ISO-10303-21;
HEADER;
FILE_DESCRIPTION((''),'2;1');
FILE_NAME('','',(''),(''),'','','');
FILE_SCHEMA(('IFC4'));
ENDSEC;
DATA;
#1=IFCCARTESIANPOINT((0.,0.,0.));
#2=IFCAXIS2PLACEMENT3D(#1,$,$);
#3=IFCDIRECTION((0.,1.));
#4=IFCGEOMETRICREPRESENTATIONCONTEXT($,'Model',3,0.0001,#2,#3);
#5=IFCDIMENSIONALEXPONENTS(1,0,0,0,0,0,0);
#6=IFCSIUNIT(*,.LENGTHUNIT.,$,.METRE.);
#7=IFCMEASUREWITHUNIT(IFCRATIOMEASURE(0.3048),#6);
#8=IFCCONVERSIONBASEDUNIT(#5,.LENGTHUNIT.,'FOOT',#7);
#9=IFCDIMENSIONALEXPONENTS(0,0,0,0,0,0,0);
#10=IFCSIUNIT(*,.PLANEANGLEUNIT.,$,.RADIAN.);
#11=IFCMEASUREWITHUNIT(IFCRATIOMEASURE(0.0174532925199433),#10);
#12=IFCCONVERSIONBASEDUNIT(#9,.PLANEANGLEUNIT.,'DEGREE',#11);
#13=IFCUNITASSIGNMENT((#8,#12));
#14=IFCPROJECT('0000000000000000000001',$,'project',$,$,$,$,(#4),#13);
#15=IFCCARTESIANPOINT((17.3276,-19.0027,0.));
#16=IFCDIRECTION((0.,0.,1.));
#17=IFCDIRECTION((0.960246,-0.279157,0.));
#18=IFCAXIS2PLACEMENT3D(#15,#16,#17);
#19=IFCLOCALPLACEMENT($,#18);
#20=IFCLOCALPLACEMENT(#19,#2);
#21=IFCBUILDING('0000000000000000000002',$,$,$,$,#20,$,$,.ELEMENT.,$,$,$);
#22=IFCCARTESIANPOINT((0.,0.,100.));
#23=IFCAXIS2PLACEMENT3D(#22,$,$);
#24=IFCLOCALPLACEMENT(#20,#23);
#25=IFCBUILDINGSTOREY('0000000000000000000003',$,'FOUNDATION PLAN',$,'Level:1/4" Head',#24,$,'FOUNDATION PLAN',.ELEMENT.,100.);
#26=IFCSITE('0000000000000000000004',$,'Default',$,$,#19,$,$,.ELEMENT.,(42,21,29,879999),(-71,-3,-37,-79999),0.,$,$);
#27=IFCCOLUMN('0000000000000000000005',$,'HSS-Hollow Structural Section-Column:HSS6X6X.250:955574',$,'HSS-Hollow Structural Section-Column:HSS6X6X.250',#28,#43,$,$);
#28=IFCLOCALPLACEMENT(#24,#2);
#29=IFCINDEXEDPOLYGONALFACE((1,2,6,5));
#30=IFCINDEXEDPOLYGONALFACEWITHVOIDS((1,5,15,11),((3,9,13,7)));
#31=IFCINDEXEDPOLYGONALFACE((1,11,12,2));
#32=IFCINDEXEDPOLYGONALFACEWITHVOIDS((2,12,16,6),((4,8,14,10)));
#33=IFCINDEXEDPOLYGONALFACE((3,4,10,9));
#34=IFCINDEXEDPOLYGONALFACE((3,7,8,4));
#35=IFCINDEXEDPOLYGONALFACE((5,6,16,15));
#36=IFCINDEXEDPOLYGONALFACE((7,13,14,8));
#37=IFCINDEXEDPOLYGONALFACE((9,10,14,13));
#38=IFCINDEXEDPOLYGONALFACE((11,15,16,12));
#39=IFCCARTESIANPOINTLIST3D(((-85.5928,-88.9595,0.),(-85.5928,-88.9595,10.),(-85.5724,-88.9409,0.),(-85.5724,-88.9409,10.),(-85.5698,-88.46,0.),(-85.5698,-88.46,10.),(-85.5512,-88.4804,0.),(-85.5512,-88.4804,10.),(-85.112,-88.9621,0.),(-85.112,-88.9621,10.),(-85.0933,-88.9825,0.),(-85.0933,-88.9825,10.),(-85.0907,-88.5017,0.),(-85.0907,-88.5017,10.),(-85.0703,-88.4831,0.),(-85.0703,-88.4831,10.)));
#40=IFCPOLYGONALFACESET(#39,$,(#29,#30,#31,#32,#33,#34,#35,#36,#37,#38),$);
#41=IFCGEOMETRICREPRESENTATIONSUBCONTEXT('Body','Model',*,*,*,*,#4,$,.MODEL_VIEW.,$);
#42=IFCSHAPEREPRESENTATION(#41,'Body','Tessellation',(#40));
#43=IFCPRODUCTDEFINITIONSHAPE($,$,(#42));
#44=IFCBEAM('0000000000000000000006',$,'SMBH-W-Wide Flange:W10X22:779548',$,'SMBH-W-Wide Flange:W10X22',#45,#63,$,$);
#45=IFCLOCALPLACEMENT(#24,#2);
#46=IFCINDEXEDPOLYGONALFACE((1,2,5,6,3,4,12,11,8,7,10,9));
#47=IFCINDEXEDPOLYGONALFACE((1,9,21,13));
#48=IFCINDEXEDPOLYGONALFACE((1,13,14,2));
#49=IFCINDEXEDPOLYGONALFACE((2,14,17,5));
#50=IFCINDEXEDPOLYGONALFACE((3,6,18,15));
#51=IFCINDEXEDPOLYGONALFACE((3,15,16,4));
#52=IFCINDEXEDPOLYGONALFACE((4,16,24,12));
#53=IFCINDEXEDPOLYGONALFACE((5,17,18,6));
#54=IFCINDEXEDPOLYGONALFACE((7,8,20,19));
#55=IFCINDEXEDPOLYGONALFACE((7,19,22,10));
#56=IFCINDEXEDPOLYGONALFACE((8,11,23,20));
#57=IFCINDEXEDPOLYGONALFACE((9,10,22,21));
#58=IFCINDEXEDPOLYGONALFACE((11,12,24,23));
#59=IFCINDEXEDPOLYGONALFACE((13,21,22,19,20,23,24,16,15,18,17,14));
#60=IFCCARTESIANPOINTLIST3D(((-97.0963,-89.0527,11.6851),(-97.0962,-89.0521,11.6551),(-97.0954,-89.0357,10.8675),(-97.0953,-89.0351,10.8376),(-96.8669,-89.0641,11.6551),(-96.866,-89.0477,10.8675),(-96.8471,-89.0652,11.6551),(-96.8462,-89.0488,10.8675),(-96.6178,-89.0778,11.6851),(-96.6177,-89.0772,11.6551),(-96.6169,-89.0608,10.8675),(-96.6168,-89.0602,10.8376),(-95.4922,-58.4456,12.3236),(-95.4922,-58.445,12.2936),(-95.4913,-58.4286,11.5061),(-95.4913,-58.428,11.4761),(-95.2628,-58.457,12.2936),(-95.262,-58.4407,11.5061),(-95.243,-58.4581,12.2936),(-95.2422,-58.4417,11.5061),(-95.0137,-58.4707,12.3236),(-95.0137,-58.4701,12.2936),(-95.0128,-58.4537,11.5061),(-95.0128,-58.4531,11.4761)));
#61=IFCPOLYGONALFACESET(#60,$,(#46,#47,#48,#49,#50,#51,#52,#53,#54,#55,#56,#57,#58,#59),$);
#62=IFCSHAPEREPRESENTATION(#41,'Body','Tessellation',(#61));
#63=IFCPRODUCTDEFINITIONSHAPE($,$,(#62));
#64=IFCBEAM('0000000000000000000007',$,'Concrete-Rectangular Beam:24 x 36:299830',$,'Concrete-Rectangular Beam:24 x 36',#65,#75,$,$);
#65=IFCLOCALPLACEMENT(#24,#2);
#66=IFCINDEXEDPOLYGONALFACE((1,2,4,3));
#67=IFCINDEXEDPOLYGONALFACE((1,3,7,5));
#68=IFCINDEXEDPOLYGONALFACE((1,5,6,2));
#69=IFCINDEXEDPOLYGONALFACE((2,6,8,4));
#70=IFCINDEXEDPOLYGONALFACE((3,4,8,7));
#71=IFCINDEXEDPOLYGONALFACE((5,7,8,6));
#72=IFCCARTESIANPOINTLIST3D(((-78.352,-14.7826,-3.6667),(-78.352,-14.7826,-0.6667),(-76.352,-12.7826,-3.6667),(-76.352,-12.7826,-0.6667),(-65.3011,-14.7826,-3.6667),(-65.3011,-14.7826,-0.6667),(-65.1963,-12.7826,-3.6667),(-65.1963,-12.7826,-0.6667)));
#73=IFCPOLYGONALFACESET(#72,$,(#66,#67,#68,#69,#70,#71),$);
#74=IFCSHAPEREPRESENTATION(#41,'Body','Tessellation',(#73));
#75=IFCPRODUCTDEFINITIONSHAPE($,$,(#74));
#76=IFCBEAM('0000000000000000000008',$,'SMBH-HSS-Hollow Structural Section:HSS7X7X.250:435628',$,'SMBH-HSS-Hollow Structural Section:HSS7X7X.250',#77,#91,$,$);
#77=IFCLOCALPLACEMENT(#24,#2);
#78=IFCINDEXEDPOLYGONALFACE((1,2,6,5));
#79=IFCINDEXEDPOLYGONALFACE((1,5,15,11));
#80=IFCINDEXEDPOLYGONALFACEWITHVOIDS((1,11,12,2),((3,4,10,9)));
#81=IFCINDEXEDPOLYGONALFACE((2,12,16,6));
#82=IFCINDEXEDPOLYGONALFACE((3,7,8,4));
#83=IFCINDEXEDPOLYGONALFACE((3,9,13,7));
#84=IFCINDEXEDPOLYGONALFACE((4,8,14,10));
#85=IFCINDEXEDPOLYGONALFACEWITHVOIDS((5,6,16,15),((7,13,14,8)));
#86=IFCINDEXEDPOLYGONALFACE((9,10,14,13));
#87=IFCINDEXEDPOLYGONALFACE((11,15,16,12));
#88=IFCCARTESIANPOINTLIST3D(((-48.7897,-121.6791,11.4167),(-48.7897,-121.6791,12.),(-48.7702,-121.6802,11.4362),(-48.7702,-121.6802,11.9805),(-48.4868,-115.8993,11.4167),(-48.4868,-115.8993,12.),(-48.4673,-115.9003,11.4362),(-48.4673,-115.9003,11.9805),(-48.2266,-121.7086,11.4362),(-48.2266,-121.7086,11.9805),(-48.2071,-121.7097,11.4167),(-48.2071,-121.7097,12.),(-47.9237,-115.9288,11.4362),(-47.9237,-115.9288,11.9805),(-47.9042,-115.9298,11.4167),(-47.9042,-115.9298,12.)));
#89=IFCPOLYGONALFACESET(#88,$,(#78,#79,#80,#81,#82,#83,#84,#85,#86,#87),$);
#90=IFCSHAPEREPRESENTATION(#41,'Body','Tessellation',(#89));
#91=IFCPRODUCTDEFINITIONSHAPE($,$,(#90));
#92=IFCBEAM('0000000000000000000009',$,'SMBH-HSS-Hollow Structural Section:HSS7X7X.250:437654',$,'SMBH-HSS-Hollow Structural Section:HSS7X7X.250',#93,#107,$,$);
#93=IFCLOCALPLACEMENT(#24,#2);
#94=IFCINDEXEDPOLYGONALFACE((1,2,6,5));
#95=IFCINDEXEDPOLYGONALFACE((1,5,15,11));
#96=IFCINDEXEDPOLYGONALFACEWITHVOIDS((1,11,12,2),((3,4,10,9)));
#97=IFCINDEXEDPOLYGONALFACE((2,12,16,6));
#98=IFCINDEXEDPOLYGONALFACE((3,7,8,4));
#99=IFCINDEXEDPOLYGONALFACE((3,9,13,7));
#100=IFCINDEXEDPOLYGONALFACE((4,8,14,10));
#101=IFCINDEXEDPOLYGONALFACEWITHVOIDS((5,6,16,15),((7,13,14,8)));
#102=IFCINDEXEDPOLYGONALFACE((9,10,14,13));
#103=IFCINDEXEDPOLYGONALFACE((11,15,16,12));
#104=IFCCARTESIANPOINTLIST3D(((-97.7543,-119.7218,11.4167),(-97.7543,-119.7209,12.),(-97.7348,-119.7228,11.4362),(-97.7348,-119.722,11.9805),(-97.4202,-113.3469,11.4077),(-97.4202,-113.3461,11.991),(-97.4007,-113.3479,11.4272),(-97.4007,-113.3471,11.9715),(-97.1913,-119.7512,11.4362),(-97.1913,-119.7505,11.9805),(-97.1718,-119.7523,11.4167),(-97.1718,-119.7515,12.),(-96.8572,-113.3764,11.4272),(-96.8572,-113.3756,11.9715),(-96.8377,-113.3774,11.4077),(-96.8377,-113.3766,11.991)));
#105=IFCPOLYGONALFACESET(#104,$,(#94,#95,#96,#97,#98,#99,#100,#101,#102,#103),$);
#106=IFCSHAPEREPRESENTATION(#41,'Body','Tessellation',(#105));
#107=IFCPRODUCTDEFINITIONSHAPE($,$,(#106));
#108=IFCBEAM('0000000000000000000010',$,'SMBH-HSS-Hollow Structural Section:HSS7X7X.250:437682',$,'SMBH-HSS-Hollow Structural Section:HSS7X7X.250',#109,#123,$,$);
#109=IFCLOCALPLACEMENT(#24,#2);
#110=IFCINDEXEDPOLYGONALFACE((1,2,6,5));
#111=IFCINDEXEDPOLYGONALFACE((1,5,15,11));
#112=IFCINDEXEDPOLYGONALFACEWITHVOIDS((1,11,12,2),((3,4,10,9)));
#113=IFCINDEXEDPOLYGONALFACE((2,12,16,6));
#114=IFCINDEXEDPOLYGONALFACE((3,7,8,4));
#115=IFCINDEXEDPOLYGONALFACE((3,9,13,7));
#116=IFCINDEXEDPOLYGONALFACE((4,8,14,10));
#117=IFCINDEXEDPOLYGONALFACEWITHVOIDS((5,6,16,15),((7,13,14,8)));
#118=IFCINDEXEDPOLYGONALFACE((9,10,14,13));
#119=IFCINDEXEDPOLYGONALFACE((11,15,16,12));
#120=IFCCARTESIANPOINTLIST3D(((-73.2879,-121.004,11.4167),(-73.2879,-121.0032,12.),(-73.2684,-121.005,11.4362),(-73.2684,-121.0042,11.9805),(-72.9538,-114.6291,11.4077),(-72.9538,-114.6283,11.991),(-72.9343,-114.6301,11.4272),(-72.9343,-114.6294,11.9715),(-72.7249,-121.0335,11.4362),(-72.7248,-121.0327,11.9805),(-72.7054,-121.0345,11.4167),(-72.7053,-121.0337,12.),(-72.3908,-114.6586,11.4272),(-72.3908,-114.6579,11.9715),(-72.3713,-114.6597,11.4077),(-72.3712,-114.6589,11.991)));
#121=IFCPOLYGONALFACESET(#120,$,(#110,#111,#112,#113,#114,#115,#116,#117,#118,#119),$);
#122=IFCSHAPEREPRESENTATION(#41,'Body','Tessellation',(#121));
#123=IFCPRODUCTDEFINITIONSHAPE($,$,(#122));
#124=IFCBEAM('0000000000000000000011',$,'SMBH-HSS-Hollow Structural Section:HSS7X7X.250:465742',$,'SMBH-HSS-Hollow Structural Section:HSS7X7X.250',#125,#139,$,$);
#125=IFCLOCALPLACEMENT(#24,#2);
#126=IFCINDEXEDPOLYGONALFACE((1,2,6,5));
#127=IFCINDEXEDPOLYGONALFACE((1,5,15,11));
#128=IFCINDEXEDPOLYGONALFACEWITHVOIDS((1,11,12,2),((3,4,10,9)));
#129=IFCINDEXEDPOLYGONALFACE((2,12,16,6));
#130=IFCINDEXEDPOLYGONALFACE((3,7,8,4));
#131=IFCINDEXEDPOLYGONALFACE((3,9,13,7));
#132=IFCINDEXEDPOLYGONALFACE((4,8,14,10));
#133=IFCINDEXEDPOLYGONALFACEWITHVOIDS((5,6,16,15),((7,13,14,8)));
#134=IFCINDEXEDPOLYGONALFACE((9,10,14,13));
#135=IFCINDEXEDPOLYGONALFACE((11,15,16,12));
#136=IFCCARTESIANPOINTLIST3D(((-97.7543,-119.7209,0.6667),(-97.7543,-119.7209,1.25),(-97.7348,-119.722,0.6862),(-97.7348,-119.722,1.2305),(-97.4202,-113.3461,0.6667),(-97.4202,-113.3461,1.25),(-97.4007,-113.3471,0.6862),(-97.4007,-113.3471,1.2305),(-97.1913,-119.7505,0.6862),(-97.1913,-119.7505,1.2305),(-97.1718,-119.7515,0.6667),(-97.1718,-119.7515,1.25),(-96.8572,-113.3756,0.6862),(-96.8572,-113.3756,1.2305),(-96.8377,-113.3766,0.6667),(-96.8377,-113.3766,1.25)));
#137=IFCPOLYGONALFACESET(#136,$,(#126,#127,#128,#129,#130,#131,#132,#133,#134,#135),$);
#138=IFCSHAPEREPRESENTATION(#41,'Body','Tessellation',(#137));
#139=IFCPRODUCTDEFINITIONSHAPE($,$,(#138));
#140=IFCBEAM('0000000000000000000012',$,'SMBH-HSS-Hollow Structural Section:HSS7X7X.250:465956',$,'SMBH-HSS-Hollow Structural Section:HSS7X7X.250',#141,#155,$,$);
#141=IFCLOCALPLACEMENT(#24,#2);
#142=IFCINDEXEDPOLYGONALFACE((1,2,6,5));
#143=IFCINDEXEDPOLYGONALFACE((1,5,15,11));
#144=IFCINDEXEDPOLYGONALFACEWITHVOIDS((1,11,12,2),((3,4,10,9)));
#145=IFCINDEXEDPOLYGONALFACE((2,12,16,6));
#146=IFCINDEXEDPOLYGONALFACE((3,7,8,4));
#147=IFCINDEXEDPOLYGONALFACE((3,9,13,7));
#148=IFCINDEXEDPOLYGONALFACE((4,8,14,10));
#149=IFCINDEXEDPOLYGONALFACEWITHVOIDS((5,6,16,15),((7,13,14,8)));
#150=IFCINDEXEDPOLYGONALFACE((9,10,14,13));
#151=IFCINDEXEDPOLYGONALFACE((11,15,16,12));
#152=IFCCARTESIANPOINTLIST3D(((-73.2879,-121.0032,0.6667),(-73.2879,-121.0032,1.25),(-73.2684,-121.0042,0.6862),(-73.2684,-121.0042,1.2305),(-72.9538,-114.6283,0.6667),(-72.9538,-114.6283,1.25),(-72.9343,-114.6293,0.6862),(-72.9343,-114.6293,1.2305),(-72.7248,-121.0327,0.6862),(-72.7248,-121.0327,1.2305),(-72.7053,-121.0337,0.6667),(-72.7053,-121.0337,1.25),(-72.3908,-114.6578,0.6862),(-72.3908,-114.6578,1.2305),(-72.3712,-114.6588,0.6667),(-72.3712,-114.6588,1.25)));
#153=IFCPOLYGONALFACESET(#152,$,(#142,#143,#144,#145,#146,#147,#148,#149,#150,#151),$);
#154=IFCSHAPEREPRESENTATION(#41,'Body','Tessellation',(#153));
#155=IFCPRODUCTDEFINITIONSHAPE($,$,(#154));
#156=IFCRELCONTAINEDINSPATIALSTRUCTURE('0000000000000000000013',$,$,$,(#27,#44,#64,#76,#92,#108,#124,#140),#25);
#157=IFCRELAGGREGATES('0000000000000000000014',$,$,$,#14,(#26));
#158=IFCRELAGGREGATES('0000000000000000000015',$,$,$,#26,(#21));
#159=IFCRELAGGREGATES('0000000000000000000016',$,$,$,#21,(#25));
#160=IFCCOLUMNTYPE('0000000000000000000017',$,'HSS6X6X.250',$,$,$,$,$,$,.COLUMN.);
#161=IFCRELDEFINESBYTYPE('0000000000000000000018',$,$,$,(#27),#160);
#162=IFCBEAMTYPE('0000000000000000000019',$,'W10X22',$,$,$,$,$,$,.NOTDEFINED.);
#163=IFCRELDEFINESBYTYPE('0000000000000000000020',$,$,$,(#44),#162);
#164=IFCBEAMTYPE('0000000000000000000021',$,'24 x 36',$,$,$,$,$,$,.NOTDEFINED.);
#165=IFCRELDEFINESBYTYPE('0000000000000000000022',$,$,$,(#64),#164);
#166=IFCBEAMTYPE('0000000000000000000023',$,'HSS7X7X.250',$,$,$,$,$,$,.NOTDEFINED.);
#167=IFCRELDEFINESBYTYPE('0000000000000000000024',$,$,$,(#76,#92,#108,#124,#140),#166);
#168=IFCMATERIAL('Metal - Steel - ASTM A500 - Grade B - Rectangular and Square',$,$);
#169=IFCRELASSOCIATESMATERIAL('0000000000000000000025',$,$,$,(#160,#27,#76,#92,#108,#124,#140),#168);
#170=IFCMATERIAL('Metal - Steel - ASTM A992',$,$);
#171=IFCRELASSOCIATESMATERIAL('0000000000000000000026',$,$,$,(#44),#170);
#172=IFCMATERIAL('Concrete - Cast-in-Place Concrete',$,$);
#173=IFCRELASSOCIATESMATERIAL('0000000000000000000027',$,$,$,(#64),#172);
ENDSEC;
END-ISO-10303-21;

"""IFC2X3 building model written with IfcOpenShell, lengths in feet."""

from ifc_helpers import new_model, entity, si_unit, converted_unit, direction, frame, frame_2d, origin, origin_2d_with_axis, place, context, subcontext, project, spatial, rectangle, i_section, extrude, boolean, clip, halfspace, source, transform, mapped, material, type_object, type_shapes, element, save


model = new_model("IFC2X3")

# Units and contexts
model_context = context("Model", 3, precision=0.0001, world=origin(), true_north=direction((0.0, 1.0)))
body_context = subcontext(model_context, "Body", "Model", "MODEL_VIEW")
ifc_project = project(units=[converted_unit("LENGTHUNIT", "FOOT", entity("IfcRatioMeasure", 0.3048), si_unit("LENGTHUNIT", "METRE"), dimensions=[1, 0, 0, 0, 0, 0, 0]), converted_unit("PLANEANGLEUNIT", "DEGREE", entity("IfcRatioMeasure", 0.0174532925199433), si_unit("PLANEANGLEUNIT", "RADIAN"), dimensions=[0, 0, 0, 0, 0, 0, 0])], contexts=[model_context])

# Site, building, storey
site_placement = place(None, frame((17.3276, -19.0027, 0.0), z_axis=(0.0, 0.0, 1.0), x_axis=(0.960246, -0.279157, 0.0)))
site = spatial("IfcSite", under=ifc_project, at=site_placement, Name="Default", CompositionType="ELEMENT", RefLatitude=(42, 21, 29, 879999), RefLongitude=(-71, -3, -37, -79999), RefElevation=0.0)
building_placement = place(site_placement, origin())
building = spatial("IfcBuilding", under=site, at=building_placement, CompositionType="ELEMENT")
storey_placement = place(building_placement, frame((0.0, 0.0, 100.0)))
storey = spatial("IfcBuildingStorey", under=building, at=storey_placement, Name="FOUNDATION PLAN", ObjectType="Level:1/4\" Head", LongName="FOUNDATION PLAN", CompositionType="ELEMENT", Elevation=100.0)

# Column
ifc_material_1 = material(Name="Metal - Steel - ASTM A500 - Grade B - Rectangular and Square")
column_type_1 = type_object("IfcColumnType", Name="HSS6X6X.250", PredefinedType="COLUMN", material=ifc_material_1)
shared_shape_1 = source(origin(), body_context, "Body", "SweptSolid", [
    boolean("DIFFERENCE", extrude(rectangle(XDim=0.5, YDim=0.5, at=origin_2d_with_axis()), frame((0.0, 0.0, 100.0), z_axis=(0.0, 0.0, 1.0), x_axis=(0.0, -1.0, 0.0)), (0.0, 0.0, 1.0), 10.0), extrude(rectangle(XDim=0.4609, YDim=0.4609, at=origin_2d_with_axis()), frame((0.0, 0.0, 110.0), z_axis=(0.0, 0.0, -1.0), x_axis=(0.0, -1.0, 0.0)), (0.0, 0.0, 1.0), 10.0)),
])
type_shapes(column_type_1, [shared_shape_1])
column_1_placement = place(storey_placement, frame((-85.3316, -88.7213, -100.0), z_axis=(0.0, 0.0, 1.0), x_axis=(-0.998937, 0.0461, 0.0)))
element("IfcColumn", 1, at=column_1_placement, inside=storey, type_object=column_type_1, material=ifc_material_1, Name="HSS-Hollow Structural Section-Column:HSS6X6X.250:955574", ObjectType="HSS-Hollow Structural Section-Column:HSS6X6X.250", context=body_context, shape_type="MappedRepresentation", body=[
    mapped(shared_shape_1, transform((0.0, 0.0, 0.0), scale=1.0)),
])

# Beams
ifc_material_2 = material(Name="Metal - Steel - ASTM A992")
beam_type_1 = type_object("IfcBeamType", Name="W10X22", PredefinedType="NOTDEFINED")
beam_1_placement = place(storey_placement, frame((-96.8571, -89.0679, 11.81), z_axis=(-0.00109, -0.0208, 0.999783), x_axis=(0.052325, 0.998413, 0.020829)))
element("IfcBeam", 2, at=beam_1_placement, inside=storey, type_object=beam_type_1, material=ifc_material_2, Name="SMBH-W-Wide Flange:W10X22:779548", ObjectType="SMBH-W-Wide Flange:W10X22", context=body_context, shape_type="SweptSolid", body=[
    extrude(i_section(OverallWidth=0.4792, OverallDepth=0.8477, WebThickness=0.0199, FlangeThickness=0.0299, at=frame_2d((0.0, 0.0), x_axis=(0.0, 1.0))), frame((0.0, 0.0, -0.5488), z_axis=(1.0, 0.0, 0.0), x_axis=(0.0, 0.0, -1.0)), (0.0, 0.0, 1.0), 30.6557),
])
ifc_material_3 = material(Name="Concrete - Cast-in-Place Concrete")
beam_type_2 = type_object("IfcBeamType", Name="24 x 36", PredefinedType="NOTDEFINED")
beam_2_placement = place(storey_placement, frame((-77.352, -13.7826, -0.6667)))
element("IfcBeam", 3, at=beam_2_placement, inside=storey, type_object=beam_type_2, material=ifc_material_3, Name="Concrete-Rectangular Beam:24 x 36:299830", ObjectType="Concrete-Rectangular Beam:24 x 36", context=body_context, shape_type="SweptSolid", body=[
    clip(clip(extrude(rectangle(XDim=3.0, YDim=2.0, at=frame_2d((0.0, 0.0), x_axis=(1.0, 0.0))), frame((-1.0, 0.0, -1.5), z_axis=(1.0, 0.0, 0.0), x_axis=(0.0, 0.0, -1.0)), (0.0, 0.0, 1.0), 13.1557), halfspace(frame((1.0, 1.0, 0.0), z_axis=(-0.707107, 0.707107, 0.0), x_axis=(0.707107, 0.707107, 0.0)), False)), halfspace(frame((12.0046, -1.8823, 0.0), z_axis=(0.99863, -0.052336, 0.0), x_axis=(0.052336, 0.99863, 0.0)), False)),
])
beam_type_3 = type_object("IfcBeamType", Name="HSS7X7X.250", PredefinedType="NOTDEFINED")
beam_3_placement = place(storey_placement, frame((-48.1955, -115.9145, 12.0), z_axis=(0.0, 0.0, 1.0), x_axis=(-0.052336, -0.99863, 0.0)))
element("IfcBeam", 4, at=beam_3_placement, inside=storey, type_object=beam_type_3, material=ifc_material_1, Name="SMBH-HSS-Hollow Structural Section:HSS7X7X.250:435628", ObjectType="SMBH-HSS-Hollow Structural Section:HSS7X7X.250", context=body_context, shape_type="SweptSolid", body=[
    boolean("DIFFERENCE", extrude(rectangle(XDim=0.5833, YDim=0.5833, at=frame_2d((0.0, 0.0), x_axis=(1.0, 0.0))), frame((0.0, 0.0, -0.2917), z_axis=(1.0, 0.0, 0.0), x_axis=(0.0, 0.0, -1.0)), (0.0, 0.0, 1.0), 5.7878), extrude(rectangle(XDim=0.5443, YDim=0.5443, at=frame_2d((0.0, 0.0), x_axis=(0.0, 1.0))), frame((5.7878, 0.0, -0.2917), z_axis=(-1.0, 0.0, 0.0), x_axis=(0.0, 1.0, 0.0)), (0.0, 0.0, 1.0), 5.7878)),
])
beam_4_placement = place(storey_placement, frame((-97.1289, -113.3614, 11.991), z_axis=(0.000073, 0.001402, 0.999999), x_axis=(-0.052336, -0.998629, 0.001403)))
element("IfcBeam", 5, at=beam_4_placement, inside=storey, type_object=beam_type_3, material=ifc_material_1, Name="SMBH-HSS-Hollow Structural Section:HSS7X7X.250:437654", ObjectType="SMBH-HSS-Hollow Structural Section:HSS7X7X.250", context=body_context, shape_type="SweptSolid", body=[
    boolean("DIFFERENCE", extrude(rectangle(XDim=0.5833, YDim=0.5833, at=frame_2d((0.0, 0.0), x_axis=(1.0, 0.0))), frame((0.0, 0.0, -0.2917), z_axis=(1.0, 0.0, 0.0), x_axis=(0.0, 0.0, -1.0)), (0.0, 0.0, 1.0), 6.3836), extrude(rectangle(XDim=0.5443, YDim=0.5443, at=frame_2d((0.0, 0.0), x_axis=(0.0, 1.0))), frame((6.3836, 0.0, -0.2917), z_axis=(-1.0, 0.0, 0.0), x_axis=(0.0, 1.0, 0.0)), (0.0, 0.0, 1.0), 6.3836)),
])
beam_5_placement = place(storey_placement, frame((-72.6625, -114.6436, 11.991), z_axis=(0.000073, 0.001402, 0.999999), x_axis=(-0.052336, -0.998629, 0.001403)))
element("IfcBeam", 6, at=beam_5_placement, inside=storey, type_object=beam_type_3, material=ifc_material_1, Name="SMBH-HSS-Hollow Structural Section:HSS7X7X.250:437682", ObjectType="SMBH-HSS-Hollow Structural Section:HSS7X7X.250", context=body_context, shape_type="SweptSolid", body=[
    boolean("DIFFERENCE", extrude(rectangle(XDim=0.5833, YDim=0.5833, at=frame_2d((0.0, 0.0), x_axis=(1.0, 0.0))), frame((0.0, 0.0, -0.2917), z_axis=(1.0, 0.0, 0.0), x_axis=(0.0, 0.0, -1.0)), (0.0, 0.0, 1.0), 6.3836), extrude(rectangle(XDim=0.5443, YDim=0.5443, at=frame_2d((0.0, 0.0), x_axis=(0.0, 1.0))), frame((6.3836, 0.0, -0.2917), z_axis=(-1.0, 0.0, 0.0), x_axis=(0.0, 1.0, 0.0)), (0.0, 0.0, 1.0), 6.3836)),
])
beam_6_placement = place(storey_placement, frame((-97.1289, -113.3614, 1.25), z_axis=(0.0, 0.0, 1.0), x_axis=(-0.052336, -0.99863, 0.0)))
element("IfcBeam", 7, at=beam_6_placement, inside=storey, type_object=beam_type_3, material=ifc_material_1, Name="SMBH-HSS-Hollow Structural Section:HSS7X7X.250:465742", ObjectType="SMBH-HSS-Hollow Structural Section:HSS7X7X.250", context=body_context, shape_type="SweptSolid", body=[
    boolean("DIFFERENCE", extrude(rectangle(XDim=0.5833, YDim=0.5833, at=frame_2d((0.0, 0.0), x_axis=(1.0, 0.0))), frame((0.0, 0.0, -0.2917), z_axis=(1.0, 0.0, 0.0), x_axis=(0.0, 0.0, -1.0)), (0.0, 0.0, 1.0), 6.3836), extrude(rectangle(XDim=0.5443, YDim=0.5443, at=frame_2d((0.0, 0.0), x_axis=(0.0, 1.0))), frame((6.3836, 0.0, -0.2917), z_axis=(-1.0, 0.0, 0.0), x_axis=(0.0, 1.0, 0.0)), (0.0, 0.0, 1.0), 6.3836)),
])
beam_7_placement = place(storey_placement, frame((-72.6625, -114.6436, 1.25), z_axis=(0.0, 0.0, 1.0), x_axis=(-0.052336, -0.99863, 0.0)))
element("IfcBeam", 8, at=beam_7_placement, inside=storey, type_object=beam_type_3, material=ifc_material_1, Name="SMBH-HSS-Hollow Structural Section:HSS7X7X.250:465956", ObjectType="SMBH-HSS-Hollow Structural Section:HSS7X7X.250", context=body_context, shape_type="SweptSolid", body=[
    boolean("DIFFERENCE", extrude(rectangle(XDim=0.5833, YDim=0.5833, at=frame_2d((0.0, 0.0), x_axis=(1.0, 0.0))), frame((0.0, 0.0, -0.2917), z_axis=(1.0, 0.0, 0.0), x_axis=(0.0, 0.0, -1.0)), (0.0, 0.0, 1.0), 6.3836), extrude(rectangle(XDim=0.5443, YDim=0.5443, at=frame_2d((0.0, 0.0), x_axis=(0.0, 1.0))), frame((6.3836, 0.0, -0.2917), z_axis=(-1.0, 0.0, 0.0), x_axis=(0.0, 1.0, 0.0)), (0.0, 0.0, 1.0), 6.3836)),
])

save(model, "model.ifc")
